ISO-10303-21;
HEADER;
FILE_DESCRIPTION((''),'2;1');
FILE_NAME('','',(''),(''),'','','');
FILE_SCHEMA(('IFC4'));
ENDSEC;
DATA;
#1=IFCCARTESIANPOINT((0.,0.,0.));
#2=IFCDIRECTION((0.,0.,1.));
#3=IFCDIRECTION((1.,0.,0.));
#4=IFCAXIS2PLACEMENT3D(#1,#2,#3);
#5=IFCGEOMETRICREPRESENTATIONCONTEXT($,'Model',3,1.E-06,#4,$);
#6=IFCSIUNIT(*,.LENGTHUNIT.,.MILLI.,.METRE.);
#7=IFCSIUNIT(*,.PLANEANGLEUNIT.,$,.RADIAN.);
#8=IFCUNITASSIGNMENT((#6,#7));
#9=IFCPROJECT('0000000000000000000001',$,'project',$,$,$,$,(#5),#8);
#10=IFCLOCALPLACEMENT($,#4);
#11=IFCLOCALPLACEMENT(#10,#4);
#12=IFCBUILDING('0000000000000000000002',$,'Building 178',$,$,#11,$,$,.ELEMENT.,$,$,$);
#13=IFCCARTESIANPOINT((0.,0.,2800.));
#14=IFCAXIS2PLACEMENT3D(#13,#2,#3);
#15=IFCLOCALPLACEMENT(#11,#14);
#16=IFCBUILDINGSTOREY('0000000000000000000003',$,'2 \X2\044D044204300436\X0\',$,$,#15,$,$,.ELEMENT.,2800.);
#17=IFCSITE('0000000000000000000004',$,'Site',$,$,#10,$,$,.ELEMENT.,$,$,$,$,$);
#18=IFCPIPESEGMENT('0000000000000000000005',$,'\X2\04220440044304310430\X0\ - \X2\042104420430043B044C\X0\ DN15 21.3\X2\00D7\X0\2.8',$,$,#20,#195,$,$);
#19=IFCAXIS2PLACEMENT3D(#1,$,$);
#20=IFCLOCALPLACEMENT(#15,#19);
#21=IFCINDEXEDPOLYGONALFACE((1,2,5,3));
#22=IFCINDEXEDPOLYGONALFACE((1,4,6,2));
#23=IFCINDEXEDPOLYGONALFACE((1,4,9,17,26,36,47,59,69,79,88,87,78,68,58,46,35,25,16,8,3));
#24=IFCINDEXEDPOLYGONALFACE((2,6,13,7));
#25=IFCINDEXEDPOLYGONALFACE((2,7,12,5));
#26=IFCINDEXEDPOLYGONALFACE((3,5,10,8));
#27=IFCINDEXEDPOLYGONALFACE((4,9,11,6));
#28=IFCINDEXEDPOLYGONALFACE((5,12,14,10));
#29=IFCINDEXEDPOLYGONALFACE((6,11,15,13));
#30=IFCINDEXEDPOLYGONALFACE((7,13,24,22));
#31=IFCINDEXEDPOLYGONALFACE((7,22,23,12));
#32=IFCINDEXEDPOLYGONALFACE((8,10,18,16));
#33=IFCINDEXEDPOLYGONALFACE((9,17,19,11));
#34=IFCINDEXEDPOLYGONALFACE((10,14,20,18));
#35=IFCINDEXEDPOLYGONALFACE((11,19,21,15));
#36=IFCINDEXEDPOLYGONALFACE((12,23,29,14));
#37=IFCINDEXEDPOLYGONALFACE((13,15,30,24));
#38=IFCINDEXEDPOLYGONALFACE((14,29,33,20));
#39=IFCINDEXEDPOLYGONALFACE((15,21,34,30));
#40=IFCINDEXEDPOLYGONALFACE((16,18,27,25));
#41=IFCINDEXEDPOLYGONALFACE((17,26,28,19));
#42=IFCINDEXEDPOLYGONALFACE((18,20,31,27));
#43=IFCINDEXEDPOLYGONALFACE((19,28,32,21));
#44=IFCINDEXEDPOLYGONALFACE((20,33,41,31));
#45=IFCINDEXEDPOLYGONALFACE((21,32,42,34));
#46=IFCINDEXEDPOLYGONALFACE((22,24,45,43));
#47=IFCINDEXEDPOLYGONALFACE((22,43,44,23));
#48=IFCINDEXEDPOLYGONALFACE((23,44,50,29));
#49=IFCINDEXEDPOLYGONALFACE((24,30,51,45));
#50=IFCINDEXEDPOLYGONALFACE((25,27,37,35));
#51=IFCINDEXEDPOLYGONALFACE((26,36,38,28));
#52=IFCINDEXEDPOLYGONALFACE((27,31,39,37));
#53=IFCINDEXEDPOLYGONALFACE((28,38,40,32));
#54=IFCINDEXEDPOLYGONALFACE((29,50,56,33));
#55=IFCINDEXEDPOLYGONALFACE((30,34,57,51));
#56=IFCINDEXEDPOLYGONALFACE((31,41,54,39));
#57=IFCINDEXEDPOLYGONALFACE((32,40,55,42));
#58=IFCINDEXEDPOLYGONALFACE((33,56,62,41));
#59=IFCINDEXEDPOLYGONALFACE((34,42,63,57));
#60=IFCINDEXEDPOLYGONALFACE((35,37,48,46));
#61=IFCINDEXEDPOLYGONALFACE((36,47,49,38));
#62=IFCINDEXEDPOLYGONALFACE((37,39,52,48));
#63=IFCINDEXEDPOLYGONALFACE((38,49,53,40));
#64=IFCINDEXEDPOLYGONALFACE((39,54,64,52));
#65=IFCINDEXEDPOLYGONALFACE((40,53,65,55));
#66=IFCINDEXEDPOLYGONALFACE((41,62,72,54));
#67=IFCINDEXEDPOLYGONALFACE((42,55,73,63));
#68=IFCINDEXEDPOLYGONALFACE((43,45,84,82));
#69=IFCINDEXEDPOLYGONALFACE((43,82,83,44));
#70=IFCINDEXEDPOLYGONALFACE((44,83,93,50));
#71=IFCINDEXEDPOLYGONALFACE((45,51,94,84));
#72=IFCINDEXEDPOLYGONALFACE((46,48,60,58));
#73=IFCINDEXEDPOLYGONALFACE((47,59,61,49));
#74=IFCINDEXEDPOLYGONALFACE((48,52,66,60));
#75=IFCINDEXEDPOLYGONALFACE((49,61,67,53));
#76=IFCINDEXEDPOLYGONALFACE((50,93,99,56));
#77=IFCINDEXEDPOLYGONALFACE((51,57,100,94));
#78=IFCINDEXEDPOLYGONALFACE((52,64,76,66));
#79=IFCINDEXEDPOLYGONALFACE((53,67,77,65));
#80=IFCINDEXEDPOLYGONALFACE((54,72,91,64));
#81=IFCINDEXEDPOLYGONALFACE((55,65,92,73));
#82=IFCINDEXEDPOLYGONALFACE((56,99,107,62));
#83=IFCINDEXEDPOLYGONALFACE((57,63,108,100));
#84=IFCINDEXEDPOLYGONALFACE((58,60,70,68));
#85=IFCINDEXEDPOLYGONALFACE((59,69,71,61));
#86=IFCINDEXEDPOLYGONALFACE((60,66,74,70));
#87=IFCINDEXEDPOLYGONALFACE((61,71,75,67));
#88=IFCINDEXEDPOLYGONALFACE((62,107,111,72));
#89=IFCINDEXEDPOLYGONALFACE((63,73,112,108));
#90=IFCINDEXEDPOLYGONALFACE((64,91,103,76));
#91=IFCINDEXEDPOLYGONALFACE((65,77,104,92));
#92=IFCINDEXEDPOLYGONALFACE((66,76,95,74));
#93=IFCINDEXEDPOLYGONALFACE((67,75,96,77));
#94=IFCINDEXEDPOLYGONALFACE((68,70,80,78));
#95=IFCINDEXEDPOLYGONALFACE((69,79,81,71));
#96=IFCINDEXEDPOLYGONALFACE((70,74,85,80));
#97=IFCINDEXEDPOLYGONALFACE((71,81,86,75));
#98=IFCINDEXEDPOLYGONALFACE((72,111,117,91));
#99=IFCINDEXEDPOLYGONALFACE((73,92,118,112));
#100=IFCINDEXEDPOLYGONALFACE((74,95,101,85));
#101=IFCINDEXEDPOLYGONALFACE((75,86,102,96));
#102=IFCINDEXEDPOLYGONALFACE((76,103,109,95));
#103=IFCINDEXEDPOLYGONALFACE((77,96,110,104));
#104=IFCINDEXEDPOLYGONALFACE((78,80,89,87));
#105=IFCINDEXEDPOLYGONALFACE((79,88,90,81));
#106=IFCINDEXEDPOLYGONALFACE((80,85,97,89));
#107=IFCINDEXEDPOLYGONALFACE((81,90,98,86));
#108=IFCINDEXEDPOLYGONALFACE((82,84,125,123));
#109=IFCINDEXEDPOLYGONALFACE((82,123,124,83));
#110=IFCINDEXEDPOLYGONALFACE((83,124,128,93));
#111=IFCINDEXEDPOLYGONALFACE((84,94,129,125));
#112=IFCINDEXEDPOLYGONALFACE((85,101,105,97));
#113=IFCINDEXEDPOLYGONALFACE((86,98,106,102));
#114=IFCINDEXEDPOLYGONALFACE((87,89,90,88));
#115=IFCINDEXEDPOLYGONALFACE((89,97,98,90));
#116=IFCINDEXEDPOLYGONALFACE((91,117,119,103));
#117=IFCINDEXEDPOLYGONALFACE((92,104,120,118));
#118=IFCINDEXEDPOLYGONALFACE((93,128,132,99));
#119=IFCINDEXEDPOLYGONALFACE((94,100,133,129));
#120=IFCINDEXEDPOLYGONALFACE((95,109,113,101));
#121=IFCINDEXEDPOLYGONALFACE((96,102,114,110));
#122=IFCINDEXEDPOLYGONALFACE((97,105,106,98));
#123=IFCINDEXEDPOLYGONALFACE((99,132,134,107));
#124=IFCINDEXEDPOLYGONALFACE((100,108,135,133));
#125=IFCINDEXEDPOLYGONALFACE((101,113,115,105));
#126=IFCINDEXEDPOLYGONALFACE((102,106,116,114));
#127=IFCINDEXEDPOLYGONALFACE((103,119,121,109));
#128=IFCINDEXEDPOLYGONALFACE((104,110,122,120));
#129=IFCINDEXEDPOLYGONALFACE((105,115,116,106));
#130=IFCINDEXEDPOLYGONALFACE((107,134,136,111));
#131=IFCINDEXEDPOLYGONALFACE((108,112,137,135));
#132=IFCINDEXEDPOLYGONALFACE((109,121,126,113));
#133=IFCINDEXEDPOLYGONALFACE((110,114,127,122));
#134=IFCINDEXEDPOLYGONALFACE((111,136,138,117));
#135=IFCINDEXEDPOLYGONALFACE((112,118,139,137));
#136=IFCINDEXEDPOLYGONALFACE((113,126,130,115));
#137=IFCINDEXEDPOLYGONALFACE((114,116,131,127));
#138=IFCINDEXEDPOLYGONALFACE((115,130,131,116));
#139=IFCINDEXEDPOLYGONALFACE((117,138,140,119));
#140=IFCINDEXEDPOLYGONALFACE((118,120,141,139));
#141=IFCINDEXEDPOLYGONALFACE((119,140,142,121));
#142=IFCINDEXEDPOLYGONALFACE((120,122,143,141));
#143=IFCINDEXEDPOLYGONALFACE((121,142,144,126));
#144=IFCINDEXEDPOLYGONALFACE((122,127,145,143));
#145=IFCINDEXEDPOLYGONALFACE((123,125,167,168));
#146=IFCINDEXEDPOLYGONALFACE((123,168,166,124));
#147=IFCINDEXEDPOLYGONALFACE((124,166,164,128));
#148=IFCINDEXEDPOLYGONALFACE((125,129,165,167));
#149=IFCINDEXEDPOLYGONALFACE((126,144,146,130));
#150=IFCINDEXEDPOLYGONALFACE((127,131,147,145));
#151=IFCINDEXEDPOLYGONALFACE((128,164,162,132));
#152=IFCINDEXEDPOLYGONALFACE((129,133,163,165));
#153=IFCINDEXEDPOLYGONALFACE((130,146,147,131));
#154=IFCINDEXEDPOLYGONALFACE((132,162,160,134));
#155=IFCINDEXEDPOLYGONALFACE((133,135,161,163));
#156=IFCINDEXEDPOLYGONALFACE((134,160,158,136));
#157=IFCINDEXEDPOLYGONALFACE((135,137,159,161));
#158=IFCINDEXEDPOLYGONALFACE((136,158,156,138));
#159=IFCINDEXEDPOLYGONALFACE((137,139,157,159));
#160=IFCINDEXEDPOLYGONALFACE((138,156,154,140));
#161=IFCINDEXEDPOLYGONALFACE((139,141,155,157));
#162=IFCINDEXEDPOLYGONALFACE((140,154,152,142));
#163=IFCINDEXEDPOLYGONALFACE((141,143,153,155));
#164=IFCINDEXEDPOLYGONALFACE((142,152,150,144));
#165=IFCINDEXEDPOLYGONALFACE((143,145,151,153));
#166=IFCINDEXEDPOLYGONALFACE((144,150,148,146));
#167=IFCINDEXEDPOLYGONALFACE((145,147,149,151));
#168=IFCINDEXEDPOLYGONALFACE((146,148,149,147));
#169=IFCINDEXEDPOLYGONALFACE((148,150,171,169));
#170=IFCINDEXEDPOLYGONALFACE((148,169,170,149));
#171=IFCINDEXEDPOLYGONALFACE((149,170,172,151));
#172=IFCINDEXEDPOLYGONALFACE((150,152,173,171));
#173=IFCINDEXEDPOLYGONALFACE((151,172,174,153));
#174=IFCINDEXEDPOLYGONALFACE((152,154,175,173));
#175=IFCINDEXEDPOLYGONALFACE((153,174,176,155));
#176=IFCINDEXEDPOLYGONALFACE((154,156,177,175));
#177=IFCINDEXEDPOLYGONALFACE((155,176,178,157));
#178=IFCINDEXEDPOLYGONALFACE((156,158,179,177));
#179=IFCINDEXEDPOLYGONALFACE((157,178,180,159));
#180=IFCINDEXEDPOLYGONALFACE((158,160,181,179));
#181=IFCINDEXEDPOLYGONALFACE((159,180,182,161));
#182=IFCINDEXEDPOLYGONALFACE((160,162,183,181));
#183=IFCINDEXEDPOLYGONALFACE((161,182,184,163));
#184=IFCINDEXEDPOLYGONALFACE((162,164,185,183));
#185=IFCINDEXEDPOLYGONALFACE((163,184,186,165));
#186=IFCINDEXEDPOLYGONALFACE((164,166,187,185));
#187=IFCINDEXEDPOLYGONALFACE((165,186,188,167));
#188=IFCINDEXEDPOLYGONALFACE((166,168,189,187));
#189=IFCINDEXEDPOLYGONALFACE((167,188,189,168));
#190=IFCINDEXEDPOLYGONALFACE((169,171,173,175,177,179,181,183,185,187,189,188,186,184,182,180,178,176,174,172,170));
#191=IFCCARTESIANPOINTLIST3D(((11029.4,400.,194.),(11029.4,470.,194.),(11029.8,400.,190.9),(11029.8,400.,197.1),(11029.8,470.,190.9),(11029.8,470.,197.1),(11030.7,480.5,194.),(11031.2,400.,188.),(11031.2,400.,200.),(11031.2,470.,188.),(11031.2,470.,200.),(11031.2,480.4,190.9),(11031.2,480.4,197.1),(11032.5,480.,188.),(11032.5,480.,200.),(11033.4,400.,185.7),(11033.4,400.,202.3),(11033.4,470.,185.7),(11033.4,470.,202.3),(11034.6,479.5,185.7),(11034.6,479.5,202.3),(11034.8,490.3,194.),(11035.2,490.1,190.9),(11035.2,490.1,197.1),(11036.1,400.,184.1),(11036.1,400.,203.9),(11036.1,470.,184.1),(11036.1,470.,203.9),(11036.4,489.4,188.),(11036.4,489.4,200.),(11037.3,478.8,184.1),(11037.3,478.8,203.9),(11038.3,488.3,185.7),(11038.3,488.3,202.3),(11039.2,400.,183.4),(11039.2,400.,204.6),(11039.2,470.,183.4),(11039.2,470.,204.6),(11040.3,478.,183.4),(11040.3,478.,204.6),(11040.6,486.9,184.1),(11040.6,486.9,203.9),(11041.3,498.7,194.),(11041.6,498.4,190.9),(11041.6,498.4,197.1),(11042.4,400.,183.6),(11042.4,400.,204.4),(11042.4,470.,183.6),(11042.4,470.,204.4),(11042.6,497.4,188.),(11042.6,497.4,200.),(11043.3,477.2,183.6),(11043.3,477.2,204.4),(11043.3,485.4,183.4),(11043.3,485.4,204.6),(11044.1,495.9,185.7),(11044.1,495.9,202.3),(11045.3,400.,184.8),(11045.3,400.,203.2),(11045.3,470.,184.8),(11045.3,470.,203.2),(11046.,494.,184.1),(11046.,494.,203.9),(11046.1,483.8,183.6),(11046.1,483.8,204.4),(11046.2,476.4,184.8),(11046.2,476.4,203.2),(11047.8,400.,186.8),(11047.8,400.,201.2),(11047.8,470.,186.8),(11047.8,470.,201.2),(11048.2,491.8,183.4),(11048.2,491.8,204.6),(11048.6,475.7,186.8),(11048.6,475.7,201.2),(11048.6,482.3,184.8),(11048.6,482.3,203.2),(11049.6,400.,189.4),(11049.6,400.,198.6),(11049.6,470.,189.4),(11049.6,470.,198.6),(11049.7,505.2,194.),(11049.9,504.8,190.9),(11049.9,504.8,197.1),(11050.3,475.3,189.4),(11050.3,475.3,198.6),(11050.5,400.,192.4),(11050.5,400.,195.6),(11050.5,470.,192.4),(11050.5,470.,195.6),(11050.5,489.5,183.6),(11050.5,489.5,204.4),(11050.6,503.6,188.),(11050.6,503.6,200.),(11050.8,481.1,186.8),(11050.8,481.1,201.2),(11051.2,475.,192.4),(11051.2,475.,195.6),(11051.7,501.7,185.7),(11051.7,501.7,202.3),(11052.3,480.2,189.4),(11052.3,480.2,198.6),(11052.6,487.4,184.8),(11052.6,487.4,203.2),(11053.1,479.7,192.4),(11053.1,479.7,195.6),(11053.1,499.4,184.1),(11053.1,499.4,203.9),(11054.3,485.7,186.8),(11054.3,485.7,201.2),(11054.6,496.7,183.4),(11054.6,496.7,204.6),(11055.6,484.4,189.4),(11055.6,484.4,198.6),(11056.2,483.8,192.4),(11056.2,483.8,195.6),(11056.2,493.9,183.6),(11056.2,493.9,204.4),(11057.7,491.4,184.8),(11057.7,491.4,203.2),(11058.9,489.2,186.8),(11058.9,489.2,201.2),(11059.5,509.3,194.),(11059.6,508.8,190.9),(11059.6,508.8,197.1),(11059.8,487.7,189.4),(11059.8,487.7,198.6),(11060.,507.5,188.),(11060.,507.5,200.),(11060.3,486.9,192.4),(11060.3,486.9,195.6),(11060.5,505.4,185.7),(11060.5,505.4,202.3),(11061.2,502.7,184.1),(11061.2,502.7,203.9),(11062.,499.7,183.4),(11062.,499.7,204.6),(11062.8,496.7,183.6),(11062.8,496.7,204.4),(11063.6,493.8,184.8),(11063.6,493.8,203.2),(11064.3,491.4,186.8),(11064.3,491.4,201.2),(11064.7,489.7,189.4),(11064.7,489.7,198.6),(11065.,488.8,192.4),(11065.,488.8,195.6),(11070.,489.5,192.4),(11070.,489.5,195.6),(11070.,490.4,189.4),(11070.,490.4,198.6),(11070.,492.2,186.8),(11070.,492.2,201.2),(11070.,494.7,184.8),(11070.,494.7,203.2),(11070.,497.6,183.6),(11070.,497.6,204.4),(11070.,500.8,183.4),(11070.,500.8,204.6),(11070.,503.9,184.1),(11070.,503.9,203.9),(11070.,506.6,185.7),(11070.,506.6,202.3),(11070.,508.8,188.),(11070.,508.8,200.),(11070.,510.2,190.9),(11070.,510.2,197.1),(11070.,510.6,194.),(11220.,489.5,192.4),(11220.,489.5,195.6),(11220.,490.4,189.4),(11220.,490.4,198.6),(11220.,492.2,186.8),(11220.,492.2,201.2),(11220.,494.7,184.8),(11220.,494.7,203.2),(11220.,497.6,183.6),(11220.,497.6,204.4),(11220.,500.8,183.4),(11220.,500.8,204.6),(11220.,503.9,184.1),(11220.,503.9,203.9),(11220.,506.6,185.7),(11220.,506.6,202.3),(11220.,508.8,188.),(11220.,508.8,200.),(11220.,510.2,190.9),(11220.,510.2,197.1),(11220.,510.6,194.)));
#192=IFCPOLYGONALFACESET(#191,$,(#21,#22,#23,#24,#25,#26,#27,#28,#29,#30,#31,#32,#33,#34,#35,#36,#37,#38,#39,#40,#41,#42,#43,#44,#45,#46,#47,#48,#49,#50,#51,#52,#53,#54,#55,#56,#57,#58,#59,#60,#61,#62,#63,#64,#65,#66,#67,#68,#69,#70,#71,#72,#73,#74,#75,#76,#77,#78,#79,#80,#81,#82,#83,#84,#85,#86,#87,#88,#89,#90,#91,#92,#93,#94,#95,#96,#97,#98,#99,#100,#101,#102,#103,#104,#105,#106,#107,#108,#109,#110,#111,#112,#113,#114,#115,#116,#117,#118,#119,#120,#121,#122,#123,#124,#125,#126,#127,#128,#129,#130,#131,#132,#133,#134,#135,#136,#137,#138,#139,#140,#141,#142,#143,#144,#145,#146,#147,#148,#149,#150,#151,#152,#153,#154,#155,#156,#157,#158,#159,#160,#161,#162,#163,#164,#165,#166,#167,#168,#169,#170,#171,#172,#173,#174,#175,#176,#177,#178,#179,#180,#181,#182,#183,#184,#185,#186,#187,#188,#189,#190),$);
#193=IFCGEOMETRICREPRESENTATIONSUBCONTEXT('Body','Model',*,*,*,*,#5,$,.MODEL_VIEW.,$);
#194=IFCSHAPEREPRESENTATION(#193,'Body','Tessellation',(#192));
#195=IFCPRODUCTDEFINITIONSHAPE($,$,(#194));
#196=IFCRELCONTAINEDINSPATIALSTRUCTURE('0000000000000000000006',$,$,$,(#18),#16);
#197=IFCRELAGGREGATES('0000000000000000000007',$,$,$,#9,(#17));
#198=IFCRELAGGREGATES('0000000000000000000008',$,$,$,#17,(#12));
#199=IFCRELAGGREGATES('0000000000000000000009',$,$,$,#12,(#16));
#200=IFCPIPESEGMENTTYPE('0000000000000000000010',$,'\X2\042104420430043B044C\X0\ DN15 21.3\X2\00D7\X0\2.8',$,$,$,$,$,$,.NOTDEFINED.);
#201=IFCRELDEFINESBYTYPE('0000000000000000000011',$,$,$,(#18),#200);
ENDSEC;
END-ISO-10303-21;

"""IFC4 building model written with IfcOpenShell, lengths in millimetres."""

from ifc_helpers import new_model, entity, si_unit, frame, origin_with_axes, place, context, subcontext, project, spatial, source, transform, mapped, type_object, element, save


model = new_model("IFC4")

# Units and contexts
model_context = context("Model", 3, precision=1e-06, world=origin_with_axes())
body_context = subcontext(model_context, "Body", "Model", "MODEL_VIEW")
ifc_project = project(units=[si_unit("LENGTHUNIT", "METRE", prefix="MILLI"), si_unit("PLANEANGLEUNIT", "RADIAN")], contexts=[model_context])

# Site, building, storey
site_placement = place(None, origin_with_axes())
site = spatial("IfcSite", under=ifc_project, at=site_placement, Name="Site", CompositionType="ELEMENT")
building_placement = place(site_placement, origin_with_axes())
building = spatial("IfcBuilding", under=site, at=building_placement, Name="Building 178", CompositionType="ELEMENT")
storey_placement = place(building_placement, frame((0.0, 0.0, 2800.0), z_axis=(0.0, 0.0, 1.0), x_axis=(1.0, 0.0, 0.0)))
storey = spatial("IfcBuildingStorey", under=building, at=storey_placement, Name="2 этаж", CompositionType="ELEMENT", Elevation=2800.0)

# Pipe segment
pipe_segment_type = type_object("IfcPipeSegmentType", Name="Сталь DN15 21.3×2.8", PredefinedType="NOTDEFINED")
shared_shape_1 = source(origin_with_axes(), body_context, "Body", "AdvancedSweptSolid", [
    entity("IfcSweptDiskSolid", entity("IfcIndexedPolyCurve", entity("IfcCartesianPointList3D", [[0.0, 0.0, 0.0], [0.0, 0.0, -70.0], [8.8, 0.0, -91.2], [30.0, 0.0, -100.0], [180.0, 0.0, -100.0]]), [entity("IfcLineIndex", [1, 2]), entity("IfcArcIndex", [2, 3, 4]), entity("IfcLineIndex", [4, 5])]), 10.7),
])
for number, where, z_axis, x_axis, name in (
    (1, (11040.0, 400.0, 194.0), (0.0, -1.0, 0.0), (1.0, 0.0, 0.0), "Труба - Сталь DN15 21.3×2.8"),
):
    element("IfcPipeSegment", number, at=place(storey_placement, frame(where, z_axis=z_axis, x_axis=x_axis)), inside=storey, type_object=pipe_segment_type, Name=name, context=body_context, shape_type="MappedRepresentation", body=[
        mapped(shared_shape_1, transform((0.0, 0.0, 0.0), x_axis=(1.0, 0.0, 0.0), y_axis=(0.0, 1.0, 0.0), z_axis=(0.0, 0.0, 1.0), scale=1.0)),
    ])

save(model, "model.ifc")
